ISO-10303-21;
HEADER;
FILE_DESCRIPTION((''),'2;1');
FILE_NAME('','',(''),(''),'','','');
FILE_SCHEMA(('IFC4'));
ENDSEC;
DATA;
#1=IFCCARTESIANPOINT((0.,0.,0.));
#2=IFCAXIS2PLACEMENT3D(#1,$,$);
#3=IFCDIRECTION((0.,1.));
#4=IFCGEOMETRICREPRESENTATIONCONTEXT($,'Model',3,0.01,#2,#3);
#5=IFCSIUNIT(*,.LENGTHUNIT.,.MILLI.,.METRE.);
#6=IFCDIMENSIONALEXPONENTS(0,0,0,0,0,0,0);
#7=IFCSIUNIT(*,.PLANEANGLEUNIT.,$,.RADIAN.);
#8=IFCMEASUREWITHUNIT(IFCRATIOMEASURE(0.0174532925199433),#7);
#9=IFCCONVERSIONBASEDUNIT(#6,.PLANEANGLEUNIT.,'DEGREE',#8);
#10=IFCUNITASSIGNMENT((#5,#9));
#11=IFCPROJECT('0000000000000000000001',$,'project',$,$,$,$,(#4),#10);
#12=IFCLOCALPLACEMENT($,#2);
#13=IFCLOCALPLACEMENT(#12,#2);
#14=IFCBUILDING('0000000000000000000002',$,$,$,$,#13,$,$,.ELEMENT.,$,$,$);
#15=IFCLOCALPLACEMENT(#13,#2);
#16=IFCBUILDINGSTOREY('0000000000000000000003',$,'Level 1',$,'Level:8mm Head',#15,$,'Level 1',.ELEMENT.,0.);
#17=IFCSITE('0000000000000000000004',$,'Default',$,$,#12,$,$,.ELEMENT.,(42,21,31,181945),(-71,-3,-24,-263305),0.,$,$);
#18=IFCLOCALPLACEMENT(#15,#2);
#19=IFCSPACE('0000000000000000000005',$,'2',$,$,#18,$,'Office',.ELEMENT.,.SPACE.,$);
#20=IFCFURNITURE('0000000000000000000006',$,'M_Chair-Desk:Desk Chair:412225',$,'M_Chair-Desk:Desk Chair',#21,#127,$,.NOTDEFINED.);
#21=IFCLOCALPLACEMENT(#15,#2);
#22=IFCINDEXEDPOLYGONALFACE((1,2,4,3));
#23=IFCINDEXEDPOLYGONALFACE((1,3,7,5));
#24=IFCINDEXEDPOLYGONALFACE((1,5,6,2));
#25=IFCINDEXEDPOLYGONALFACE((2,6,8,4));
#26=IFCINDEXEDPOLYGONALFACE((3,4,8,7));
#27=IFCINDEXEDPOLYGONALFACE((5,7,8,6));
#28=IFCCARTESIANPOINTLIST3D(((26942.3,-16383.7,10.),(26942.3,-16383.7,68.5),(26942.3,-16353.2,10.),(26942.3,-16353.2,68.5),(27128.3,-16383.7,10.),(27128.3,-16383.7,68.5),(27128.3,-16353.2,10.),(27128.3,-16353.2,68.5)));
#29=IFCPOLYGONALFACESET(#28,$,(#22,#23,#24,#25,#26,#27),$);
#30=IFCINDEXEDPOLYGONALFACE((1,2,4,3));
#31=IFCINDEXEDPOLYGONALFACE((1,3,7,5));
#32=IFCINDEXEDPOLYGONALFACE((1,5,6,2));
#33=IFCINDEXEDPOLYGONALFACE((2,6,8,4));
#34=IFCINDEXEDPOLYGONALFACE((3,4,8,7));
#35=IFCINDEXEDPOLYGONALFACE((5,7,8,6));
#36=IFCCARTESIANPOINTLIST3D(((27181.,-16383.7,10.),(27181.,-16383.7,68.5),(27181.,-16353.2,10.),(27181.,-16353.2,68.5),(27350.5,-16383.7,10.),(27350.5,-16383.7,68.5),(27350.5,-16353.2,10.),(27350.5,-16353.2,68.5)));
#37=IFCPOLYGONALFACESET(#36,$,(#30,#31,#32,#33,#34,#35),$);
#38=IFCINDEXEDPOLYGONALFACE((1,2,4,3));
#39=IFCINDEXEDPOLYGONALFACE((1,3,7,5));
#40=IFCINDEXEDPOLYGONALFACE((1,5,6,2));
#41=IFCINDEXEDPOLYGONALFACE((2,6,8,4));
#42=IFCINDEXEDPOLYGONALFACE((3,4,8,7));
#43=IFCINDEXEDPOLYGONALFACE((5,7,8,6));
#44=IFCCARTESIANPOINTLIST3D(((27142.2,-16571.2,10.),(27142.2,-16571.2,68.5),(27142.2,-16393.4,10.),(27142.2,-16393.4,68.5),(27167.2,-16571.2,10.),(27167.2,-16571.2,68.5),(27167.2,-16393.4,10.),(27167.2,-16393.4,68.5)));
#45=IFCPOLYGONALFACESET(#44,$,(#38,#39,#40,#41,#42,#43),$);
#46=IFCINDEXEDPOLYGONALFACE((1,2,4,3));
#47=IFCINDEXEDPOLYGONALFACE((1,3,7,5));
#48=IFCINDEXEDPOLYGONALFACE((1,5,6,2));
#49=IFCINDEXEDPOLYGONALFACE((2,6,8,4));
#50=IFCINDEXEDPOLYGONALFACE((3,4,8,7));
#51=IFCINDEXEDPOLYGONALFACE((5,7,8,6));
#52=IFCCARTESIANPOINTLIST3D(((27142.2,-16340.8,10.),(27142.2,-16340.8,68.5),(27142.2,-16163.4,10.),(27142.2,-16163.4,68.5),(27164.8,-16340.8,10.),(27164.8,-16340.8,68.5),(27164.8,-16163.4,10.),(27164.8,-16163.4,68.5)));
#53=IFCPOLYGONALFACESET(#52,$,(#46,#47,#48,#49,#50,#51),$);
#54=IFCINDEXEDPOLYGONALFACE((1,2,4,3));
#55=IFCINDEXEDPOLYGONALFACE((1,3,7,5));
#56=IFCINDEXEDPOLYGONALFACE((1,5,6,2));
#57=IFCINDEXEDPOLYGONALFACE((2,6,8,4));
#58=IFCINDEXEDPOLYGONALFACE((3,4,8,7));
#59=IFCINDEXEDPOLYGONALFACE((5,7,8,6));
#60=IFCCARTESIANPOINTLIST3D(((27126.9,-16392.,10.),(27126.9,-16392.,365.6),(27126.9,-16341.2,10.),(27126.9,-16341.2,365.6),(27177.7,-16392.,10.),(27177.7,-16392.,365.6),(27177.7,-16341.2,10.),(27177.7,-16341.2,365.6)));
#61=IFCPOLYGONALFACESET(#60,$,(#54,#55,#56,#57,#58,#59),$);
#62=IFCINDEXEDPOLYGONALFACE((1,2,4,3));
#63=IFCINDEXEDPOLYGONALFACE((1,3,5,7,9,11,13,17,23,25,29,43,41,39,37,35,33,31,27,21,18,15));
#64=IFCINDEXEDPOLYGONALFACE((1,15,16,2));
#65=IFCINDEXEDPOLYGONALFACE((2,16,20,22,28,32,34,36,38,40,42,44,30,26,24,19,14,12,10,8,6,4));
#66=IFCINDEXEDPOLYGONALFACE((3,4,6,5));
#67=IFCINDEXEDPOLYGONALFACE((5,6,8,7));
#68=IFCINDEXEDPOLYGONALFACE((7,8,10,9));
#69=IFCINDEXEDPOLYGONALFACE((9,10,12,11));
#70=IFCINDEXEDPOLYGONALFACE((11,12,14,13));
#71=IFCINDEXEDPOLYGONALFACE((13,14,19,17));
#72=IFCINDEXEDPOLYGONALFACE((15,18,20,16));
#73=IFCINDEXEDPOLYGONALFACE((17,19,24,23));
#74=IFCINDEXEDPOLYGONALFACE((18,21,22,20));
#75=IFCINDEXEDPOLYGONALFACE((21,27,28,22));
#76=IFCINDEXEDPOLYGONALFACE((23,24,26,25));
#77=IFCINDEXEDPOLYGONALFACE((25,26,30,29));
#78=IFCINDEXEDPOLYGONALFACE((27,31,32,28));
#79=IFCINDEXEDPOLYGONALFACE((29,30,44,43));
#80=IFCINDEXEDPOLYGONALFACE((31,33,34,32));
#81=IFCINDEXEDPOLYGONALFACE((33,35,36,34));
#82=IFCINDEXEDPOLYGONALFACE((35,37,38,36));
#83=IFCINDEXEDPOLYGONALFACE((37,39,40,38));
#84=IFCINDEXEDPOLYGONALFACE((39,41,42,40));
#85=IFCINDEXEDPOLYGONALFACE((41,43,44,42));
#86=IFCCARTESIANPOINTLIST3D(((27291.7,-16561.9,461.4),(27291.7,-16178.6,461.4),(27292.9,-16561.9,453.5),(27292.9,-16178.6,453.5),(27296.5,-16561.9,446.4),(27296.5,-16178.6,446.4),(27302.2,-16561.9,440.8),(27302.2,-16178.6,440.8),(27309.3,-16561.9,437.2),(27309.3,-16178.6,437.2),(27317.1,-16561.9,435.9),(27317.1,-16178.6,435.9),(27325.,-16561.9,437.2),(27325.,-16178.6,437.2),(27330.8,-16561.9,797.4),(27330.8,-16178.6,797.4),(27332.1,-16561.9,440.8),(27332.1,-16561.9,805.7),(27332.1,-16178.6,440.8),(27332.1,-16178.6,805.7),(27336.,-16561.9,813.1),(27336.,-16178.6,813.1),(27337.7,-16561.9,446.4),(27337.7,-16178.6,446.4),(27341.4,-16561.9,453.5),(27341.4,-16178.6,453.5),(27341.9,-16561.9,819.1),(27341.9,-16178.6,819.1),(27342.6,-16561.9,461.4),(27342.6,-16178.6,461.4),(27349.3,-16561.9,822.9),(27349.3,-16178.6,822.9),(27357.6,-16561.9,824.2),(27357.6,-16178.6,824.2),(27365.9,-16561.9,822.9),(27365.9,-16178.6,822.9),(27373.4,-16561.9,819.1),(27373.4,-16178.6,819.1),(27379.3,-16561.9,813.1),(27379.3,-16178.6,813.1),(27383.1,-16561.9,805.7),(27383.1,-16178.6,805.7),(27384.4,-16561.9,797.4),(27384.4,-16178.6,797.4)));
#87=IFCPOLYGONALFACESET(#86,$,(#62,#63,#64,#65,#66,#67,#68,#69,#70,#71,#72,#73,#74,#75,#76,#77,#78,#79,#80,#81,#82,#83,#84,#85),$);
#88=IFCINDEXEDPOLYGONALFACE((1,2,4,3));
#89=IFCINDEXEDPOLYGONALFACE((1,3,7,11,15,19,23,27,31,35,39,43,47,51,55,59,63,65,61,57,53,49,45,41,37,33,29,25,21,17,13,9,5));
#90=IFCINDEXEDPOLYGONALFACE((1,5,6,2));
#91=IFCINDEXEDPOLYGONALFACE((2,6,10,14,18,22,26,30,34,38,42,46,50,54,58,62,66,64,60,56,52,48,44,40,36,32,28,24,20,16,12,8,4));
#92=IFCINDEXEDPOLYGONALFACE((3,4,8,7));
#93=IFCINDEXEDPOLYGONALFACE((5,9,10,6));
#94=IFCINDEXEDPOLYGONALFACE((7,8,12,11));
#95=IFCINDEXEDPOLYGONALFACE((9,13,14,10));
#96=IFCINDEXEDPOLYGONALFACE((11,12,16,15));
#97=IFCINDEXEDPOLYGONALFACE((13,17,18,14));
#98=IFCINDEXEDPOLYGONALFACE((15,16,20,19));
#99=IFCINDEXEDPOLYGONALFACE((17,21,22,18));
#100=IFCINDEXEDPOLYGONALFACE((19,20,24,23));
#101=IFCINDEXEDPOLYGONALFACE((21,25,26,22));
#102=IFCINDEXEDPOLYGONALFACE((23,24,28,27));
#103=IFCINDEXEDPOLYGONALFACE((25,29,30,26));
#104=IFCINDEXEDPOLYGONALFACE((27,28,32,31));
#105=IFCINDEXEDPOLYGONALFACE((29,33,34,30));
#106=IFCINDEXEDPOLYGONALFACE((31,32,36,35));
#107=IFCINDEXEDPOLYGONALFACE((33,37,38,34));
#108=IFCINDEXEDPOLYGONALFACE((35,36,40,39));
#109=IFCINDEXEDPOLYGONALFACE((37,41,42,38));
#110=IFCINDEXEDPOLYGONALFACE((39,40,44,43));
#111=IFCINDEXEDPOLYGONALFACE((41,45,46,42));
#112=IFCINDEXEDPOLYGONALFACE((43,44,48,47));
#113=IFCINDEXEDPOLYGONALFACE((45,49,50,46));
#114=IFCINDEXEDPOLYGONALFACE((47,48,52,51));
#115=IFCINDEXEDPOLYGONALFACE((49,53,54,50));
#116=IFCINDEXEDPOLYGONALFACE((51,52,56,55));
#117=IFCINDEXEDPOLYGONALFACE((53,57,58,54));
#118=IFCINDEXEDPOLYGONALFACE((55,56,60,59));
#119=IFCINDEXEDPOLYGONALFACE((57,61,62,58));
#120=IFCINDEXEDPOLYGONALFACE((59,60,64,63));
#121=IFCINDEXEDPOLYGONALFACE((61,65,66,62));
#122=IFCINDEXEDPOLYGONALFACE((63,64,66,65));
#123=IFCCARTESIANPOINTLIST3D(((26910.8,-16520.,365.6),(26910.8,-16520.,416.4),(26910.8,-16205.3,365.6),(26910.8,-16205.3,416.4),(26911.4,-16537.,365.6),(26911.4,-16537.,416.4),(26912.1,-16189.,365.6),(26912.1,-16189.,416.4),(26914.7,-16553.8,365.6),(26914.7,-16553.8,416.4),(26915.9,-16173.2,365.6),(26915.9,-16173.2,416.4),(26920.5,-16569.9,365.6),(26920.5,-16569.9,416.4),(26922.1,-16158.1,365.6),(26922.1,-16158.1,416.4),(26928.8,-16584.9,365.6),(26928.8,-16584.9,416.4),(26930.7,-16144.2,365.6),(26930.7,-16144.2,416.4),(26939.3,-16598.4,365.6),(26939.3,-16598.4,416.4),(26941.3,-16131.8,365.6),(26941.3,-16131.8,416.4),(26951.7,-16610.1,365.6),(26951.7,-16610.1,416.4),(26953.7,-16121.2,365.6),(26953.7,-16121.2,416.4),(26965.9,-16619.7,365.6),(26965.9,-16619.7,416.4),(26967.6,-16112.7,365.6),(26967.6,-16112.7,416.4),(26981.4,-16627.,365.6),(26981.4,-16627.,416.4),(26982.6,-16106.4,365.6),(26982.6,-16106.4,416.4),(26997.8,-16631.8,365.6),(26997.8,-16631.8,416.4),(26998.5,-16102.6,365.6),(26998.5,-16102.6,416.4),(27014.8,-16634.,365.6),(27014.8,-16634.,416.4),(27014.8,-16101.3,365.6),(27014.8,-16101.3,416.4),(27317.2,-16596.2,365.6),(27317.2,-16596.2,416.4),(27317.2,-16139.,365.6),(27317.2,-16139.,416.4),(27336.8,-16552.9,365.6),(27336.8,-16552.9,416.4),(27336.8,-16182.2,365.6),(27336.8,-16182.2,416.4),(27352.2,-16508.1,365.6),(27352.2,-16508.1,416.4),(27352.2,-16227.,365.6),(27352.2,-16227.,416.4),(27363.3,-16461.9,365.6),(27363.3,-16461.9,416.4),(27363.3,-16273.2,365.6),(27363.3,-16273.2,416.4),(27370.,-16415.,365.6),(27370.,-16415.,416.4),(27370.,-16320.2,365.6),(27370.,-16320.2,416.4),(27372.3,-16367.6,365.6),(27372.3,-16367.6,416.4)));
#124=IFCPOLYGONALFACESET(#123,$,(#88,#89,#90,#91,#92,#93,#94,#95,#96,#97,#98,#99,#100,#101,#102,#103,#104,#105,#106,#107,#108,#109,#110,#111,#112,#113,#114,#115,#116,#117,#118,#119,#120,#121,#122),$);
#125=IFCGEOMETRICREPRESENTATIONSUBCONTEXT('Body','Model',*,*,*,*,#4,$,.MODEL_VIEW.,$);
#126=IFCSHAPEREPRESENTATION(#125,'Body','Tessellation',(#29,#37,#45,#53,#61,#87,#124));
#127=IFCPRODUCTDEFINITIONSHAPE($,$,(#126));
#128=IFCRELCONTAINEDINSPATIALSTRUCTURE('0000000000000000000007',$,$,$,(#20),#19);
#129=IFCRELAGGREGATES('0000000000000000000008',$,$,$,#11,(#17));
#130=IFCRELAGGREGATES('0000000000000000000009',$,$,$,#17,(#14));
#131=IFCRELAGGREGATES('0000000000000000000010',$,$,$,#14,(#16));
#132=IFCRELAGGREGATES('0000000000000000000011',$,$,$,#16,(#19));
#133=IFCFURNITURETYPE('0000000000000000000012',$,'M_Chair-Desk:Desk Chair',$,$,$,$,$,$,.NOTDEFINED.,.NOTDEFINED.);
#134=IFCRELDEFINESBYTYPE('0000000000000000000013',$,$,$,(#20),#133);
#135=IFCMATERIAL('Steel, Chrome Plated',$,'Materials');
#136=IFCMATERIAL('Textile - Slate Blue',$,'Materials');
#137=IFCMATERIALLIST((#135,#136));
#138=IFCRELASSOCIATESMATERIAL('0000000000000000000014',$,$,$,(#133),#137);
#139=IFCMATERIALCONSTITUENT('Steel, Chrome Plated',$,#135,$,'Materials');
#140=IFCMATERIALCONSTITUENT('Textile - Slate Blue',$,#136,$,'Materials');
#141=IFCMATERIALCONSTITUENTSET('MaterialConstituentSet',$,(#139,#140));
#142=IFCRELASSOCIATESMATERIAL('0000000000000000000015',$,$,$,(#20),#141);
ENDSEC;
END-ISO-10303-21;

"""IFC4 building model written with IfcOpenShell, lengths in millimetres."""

from ifc_helpers import new_model, entity, si_unit, converted_unit, direction, frame, origin, place, context, subcontext, project, spatial, indexed_curve, outline, extrude, source, transform, mapped, material, material_list, constituent, constituent_set, type_object, type_shapes, element, save


model = new_model("IFC4")

# Units and contexts
model_context = context("Model", 3, precision=0.01, world=origin(), true_north=direction((0.0, 1.0)))
body_context = subcontext(model_context, "Body", "Model", "MODEL_VIEW")
ifc_project = project(units=[si_unit("LENGTHUNIT", "METRE", prefix="MILLI"), converted_unit("PLANEANGLEUNIT", "DEGREE", entity("IfcRatioMeasure", 0.0174532925199433), si_unit("PLANEANGLEUNIT", "RADIAN"), dimensions=[0, 0, 0, 0, 0, 0, 0])], contexts=[model_context])

# Site, building, storey
site_placement = place(None, origin())
site = spatial("IfcSite", under=ifc_project, at=site_placement, Name="Default", CompositionType="ELEMENT", RefLatitude=(42, 21, 31, 181945), RefLongitude=(-71, -3, -24, -263305), RefElevation=0.0)
building_placement = place(site_placement, origin())
building = spatial("IfcBuilding", under=site, at=building_placement, CompositionType="ELEMENT")
storey_placement = place(building_placement, origin())
storey = spatial("IfcBuildingStorey", under=building, at=storey_placement, Name="Level 1", ObjectType="Level:8mm Head", LongName="Level 1", CompositionType="ELEMENT", Elevation=0.0)

# Shared definitions
space_placement = place(storey_placement, origin())
space = spatial("IfcSpace", under=storey, at=space_placement, Name="2", LongName="Office", CompositionType="ELEMENT", PredefinedType="SPACE")

# Furniture
ifc_material_1 = material(Name="Steel, Chrome Plated", Category="Materials")
ifc_material_2 = material(Name="Textile - Slate Blue", Category="Materials")
ifc_material_list = material_list([ifc_material_1, ifc_material_2])
furniture_type = type_object("IfcFurnitureType", Name="M_Chair-Desk:Desk Chair", AssemblyPlace="NOTDEFINED", PredefinedType="NOTDEFINED", material=ifc_material_list)
shared_shape_1 = source(origin(), body_context, "Body", "SweptSolid", [
    extrude(outline(indexed_curve([(-15.2, -93.0), (15.2, -93.0), (15.2, 93.0), (-15.2, 93.0), (-15.2, -93.0)], self_intersect=False)), frame((-0.9, 281.9, 0.0)), (0.0, 0.0, 1.0), 58.5),
    extrude(outline(indexed_curve([(-15.2, -84.7), (15.2, -84.7), (15.2, 84.7), (-15.2, 84.7), (-15.2, -84.7)], self_intersect=False)), frame((-0.9, 51.5, 0.0), z_axis=(0.0, 0.0, 1.0), x_axis=(-1.0, 0.0, 0.0)), (0.0, 0.0, 1.0), 58.5),
    extrude(outline(indexed_curve([(-12.5, -88.9), (12.5, -88.9), (12.5, 88.9), (-12.5, 88.9), (-12.5, -88.9)], self_intersect=False)), frame((-114.8, 162.5, 0.0), z_axis=(0.0, 0.0, 1.0), x_axis=(0.0, -1.0, 0.0)), (0.0, 0.0, 1.0), 58.5),
    extrude(outline(indexed_curve([(-88.7, -11.3), (88.7, -11.3), (88.7, 11.3), (-88.7, 11.3), (-88.7, -11.3)], self_intersect=False)), frame((115.5, 163.7, 0.0), z_axis=(0.0, 0.0, 1.0), x_axis=(-1.0, 0.0, 0.0)), (0.0, 0.0, 1.0), 58.5),
    extrude(outline(indexed_curve([(-25.4, -25.4), (25.4, -25.4), (25.4, 25.4), (-25.4, 25.4), (-25.4, -25.4)], self_intersect=False)), frame((0.9, 164.9, 0.0), z_axis=(0.0, 0.0, 1.0), x_axis=(-1.0, 0.0, 0.0)), (0.0, 0.0, 1.0), 355.6),
    extrude(outline(indexed_curve([(6.5, 168.0), (5.2, 176.3), (1.4, 183.8), (-4.5, 189.7), (-12.0, 193.5), (-20.2, 194.8), (-28.5, 193.5), (-36.0, 189.7), (-41.9, 183.8), (-45.7, 176.3), (-47.0, 168.0), (-5.2, -168.0), (-4.0, -175.9), (-0.4, -183.0), (5.3, -188.6), (12.4, -192.2), (20.2, -193.5), (28.1, -192.2), (35.2, -188.6), (40.9, -183.0), (44.5, -175.9), (45.7, -168.0), (6.5, 168.0)], self_intersect=False)), frame((-194.4, -20.2, 619.4), z_axis=(1.0, 0.0, 0.0), x_axis=(0.0, 1.0, 0.0)), (0.0, 0.0, 1.0), 383.3),
    extrude(outline(indexed_curve([(-98.9, -257.7), (205.9, -257.7), (230.7, -217.3), (251.6, -174.7), (268.3, -130.3), (280.8, -84.5), (288.9, -37.7), (292.6, 9.6), (291.7, 57.0), (286.4, 104.2), (276.7, 150.6), (262.6, 195.9), (-32.8, 270.8), (-49.1, 271.5), (-65.3, 269.7), (-81.1, 265.4), (-95.9, 258.6), (-109.5, 249.7), (-121.6, 238.7), (-131.8, 225.9), (-139.8, 211.7), (-145.6, 196.5), (-148.9, 180.5), (-187.9, -131.7), (-189.4, -148.8), (-188.3, -165.8), (-184.5, -182.5), (-178.1, -198.4), (-169.4, -213.1), (-158.5, -226.2), (-145.6, -237.5), (-131.2, -246.7), (-115.5, -253.5), (-98.9, -257.7)], self_intersect=False)), frame((1.6, 236.3, 355.6), z_axis=(0.0, 0.0, 1.0), x_axis=(0.124035, -0.992278, 0.0)), (0.0, 0.0, 1.0), 50.8),
])
type_shapes(furniture_type, [shared_shape_1])
ifc_constituent_1 = constituent(ifc_material_1, Name="Steel, Chrome Plated", Category="Materials")
ifc_constituent_2 = constituent(ifc_material_2, Name="Textile - Slate Blue", Category="Materials")
ifc_constituent_set_1 = constituent_set(constituents=[ifc_constituent_1, ifc_constituent_2], Name="MaterialConstituentSet")
furniture_1_placement = place(space_placement, frame((27317.2, -16367.6, 10.0), z_axis=(0.0, 0.0, 1.0), x_axis=(0.0, 1.0, 0.0)))
element("IfcFurniture", 1, at=furniture_1_placement, inside=space, type_object=furniture_type, material=ifc_constituent_set_1, Name="M_Chair-Desk:Desk Chair:412225", ObjectType="M_Chair-Desk:Desk Chair", PredefinedType="NOTDEFINED", context=body_context, shape_type="MappedRepresentation", body=[
    mapped(shared_shape_1, transform((0.0, 0.0, 0.0), scale=1.0)),
])

save(model, "model.ifc")
